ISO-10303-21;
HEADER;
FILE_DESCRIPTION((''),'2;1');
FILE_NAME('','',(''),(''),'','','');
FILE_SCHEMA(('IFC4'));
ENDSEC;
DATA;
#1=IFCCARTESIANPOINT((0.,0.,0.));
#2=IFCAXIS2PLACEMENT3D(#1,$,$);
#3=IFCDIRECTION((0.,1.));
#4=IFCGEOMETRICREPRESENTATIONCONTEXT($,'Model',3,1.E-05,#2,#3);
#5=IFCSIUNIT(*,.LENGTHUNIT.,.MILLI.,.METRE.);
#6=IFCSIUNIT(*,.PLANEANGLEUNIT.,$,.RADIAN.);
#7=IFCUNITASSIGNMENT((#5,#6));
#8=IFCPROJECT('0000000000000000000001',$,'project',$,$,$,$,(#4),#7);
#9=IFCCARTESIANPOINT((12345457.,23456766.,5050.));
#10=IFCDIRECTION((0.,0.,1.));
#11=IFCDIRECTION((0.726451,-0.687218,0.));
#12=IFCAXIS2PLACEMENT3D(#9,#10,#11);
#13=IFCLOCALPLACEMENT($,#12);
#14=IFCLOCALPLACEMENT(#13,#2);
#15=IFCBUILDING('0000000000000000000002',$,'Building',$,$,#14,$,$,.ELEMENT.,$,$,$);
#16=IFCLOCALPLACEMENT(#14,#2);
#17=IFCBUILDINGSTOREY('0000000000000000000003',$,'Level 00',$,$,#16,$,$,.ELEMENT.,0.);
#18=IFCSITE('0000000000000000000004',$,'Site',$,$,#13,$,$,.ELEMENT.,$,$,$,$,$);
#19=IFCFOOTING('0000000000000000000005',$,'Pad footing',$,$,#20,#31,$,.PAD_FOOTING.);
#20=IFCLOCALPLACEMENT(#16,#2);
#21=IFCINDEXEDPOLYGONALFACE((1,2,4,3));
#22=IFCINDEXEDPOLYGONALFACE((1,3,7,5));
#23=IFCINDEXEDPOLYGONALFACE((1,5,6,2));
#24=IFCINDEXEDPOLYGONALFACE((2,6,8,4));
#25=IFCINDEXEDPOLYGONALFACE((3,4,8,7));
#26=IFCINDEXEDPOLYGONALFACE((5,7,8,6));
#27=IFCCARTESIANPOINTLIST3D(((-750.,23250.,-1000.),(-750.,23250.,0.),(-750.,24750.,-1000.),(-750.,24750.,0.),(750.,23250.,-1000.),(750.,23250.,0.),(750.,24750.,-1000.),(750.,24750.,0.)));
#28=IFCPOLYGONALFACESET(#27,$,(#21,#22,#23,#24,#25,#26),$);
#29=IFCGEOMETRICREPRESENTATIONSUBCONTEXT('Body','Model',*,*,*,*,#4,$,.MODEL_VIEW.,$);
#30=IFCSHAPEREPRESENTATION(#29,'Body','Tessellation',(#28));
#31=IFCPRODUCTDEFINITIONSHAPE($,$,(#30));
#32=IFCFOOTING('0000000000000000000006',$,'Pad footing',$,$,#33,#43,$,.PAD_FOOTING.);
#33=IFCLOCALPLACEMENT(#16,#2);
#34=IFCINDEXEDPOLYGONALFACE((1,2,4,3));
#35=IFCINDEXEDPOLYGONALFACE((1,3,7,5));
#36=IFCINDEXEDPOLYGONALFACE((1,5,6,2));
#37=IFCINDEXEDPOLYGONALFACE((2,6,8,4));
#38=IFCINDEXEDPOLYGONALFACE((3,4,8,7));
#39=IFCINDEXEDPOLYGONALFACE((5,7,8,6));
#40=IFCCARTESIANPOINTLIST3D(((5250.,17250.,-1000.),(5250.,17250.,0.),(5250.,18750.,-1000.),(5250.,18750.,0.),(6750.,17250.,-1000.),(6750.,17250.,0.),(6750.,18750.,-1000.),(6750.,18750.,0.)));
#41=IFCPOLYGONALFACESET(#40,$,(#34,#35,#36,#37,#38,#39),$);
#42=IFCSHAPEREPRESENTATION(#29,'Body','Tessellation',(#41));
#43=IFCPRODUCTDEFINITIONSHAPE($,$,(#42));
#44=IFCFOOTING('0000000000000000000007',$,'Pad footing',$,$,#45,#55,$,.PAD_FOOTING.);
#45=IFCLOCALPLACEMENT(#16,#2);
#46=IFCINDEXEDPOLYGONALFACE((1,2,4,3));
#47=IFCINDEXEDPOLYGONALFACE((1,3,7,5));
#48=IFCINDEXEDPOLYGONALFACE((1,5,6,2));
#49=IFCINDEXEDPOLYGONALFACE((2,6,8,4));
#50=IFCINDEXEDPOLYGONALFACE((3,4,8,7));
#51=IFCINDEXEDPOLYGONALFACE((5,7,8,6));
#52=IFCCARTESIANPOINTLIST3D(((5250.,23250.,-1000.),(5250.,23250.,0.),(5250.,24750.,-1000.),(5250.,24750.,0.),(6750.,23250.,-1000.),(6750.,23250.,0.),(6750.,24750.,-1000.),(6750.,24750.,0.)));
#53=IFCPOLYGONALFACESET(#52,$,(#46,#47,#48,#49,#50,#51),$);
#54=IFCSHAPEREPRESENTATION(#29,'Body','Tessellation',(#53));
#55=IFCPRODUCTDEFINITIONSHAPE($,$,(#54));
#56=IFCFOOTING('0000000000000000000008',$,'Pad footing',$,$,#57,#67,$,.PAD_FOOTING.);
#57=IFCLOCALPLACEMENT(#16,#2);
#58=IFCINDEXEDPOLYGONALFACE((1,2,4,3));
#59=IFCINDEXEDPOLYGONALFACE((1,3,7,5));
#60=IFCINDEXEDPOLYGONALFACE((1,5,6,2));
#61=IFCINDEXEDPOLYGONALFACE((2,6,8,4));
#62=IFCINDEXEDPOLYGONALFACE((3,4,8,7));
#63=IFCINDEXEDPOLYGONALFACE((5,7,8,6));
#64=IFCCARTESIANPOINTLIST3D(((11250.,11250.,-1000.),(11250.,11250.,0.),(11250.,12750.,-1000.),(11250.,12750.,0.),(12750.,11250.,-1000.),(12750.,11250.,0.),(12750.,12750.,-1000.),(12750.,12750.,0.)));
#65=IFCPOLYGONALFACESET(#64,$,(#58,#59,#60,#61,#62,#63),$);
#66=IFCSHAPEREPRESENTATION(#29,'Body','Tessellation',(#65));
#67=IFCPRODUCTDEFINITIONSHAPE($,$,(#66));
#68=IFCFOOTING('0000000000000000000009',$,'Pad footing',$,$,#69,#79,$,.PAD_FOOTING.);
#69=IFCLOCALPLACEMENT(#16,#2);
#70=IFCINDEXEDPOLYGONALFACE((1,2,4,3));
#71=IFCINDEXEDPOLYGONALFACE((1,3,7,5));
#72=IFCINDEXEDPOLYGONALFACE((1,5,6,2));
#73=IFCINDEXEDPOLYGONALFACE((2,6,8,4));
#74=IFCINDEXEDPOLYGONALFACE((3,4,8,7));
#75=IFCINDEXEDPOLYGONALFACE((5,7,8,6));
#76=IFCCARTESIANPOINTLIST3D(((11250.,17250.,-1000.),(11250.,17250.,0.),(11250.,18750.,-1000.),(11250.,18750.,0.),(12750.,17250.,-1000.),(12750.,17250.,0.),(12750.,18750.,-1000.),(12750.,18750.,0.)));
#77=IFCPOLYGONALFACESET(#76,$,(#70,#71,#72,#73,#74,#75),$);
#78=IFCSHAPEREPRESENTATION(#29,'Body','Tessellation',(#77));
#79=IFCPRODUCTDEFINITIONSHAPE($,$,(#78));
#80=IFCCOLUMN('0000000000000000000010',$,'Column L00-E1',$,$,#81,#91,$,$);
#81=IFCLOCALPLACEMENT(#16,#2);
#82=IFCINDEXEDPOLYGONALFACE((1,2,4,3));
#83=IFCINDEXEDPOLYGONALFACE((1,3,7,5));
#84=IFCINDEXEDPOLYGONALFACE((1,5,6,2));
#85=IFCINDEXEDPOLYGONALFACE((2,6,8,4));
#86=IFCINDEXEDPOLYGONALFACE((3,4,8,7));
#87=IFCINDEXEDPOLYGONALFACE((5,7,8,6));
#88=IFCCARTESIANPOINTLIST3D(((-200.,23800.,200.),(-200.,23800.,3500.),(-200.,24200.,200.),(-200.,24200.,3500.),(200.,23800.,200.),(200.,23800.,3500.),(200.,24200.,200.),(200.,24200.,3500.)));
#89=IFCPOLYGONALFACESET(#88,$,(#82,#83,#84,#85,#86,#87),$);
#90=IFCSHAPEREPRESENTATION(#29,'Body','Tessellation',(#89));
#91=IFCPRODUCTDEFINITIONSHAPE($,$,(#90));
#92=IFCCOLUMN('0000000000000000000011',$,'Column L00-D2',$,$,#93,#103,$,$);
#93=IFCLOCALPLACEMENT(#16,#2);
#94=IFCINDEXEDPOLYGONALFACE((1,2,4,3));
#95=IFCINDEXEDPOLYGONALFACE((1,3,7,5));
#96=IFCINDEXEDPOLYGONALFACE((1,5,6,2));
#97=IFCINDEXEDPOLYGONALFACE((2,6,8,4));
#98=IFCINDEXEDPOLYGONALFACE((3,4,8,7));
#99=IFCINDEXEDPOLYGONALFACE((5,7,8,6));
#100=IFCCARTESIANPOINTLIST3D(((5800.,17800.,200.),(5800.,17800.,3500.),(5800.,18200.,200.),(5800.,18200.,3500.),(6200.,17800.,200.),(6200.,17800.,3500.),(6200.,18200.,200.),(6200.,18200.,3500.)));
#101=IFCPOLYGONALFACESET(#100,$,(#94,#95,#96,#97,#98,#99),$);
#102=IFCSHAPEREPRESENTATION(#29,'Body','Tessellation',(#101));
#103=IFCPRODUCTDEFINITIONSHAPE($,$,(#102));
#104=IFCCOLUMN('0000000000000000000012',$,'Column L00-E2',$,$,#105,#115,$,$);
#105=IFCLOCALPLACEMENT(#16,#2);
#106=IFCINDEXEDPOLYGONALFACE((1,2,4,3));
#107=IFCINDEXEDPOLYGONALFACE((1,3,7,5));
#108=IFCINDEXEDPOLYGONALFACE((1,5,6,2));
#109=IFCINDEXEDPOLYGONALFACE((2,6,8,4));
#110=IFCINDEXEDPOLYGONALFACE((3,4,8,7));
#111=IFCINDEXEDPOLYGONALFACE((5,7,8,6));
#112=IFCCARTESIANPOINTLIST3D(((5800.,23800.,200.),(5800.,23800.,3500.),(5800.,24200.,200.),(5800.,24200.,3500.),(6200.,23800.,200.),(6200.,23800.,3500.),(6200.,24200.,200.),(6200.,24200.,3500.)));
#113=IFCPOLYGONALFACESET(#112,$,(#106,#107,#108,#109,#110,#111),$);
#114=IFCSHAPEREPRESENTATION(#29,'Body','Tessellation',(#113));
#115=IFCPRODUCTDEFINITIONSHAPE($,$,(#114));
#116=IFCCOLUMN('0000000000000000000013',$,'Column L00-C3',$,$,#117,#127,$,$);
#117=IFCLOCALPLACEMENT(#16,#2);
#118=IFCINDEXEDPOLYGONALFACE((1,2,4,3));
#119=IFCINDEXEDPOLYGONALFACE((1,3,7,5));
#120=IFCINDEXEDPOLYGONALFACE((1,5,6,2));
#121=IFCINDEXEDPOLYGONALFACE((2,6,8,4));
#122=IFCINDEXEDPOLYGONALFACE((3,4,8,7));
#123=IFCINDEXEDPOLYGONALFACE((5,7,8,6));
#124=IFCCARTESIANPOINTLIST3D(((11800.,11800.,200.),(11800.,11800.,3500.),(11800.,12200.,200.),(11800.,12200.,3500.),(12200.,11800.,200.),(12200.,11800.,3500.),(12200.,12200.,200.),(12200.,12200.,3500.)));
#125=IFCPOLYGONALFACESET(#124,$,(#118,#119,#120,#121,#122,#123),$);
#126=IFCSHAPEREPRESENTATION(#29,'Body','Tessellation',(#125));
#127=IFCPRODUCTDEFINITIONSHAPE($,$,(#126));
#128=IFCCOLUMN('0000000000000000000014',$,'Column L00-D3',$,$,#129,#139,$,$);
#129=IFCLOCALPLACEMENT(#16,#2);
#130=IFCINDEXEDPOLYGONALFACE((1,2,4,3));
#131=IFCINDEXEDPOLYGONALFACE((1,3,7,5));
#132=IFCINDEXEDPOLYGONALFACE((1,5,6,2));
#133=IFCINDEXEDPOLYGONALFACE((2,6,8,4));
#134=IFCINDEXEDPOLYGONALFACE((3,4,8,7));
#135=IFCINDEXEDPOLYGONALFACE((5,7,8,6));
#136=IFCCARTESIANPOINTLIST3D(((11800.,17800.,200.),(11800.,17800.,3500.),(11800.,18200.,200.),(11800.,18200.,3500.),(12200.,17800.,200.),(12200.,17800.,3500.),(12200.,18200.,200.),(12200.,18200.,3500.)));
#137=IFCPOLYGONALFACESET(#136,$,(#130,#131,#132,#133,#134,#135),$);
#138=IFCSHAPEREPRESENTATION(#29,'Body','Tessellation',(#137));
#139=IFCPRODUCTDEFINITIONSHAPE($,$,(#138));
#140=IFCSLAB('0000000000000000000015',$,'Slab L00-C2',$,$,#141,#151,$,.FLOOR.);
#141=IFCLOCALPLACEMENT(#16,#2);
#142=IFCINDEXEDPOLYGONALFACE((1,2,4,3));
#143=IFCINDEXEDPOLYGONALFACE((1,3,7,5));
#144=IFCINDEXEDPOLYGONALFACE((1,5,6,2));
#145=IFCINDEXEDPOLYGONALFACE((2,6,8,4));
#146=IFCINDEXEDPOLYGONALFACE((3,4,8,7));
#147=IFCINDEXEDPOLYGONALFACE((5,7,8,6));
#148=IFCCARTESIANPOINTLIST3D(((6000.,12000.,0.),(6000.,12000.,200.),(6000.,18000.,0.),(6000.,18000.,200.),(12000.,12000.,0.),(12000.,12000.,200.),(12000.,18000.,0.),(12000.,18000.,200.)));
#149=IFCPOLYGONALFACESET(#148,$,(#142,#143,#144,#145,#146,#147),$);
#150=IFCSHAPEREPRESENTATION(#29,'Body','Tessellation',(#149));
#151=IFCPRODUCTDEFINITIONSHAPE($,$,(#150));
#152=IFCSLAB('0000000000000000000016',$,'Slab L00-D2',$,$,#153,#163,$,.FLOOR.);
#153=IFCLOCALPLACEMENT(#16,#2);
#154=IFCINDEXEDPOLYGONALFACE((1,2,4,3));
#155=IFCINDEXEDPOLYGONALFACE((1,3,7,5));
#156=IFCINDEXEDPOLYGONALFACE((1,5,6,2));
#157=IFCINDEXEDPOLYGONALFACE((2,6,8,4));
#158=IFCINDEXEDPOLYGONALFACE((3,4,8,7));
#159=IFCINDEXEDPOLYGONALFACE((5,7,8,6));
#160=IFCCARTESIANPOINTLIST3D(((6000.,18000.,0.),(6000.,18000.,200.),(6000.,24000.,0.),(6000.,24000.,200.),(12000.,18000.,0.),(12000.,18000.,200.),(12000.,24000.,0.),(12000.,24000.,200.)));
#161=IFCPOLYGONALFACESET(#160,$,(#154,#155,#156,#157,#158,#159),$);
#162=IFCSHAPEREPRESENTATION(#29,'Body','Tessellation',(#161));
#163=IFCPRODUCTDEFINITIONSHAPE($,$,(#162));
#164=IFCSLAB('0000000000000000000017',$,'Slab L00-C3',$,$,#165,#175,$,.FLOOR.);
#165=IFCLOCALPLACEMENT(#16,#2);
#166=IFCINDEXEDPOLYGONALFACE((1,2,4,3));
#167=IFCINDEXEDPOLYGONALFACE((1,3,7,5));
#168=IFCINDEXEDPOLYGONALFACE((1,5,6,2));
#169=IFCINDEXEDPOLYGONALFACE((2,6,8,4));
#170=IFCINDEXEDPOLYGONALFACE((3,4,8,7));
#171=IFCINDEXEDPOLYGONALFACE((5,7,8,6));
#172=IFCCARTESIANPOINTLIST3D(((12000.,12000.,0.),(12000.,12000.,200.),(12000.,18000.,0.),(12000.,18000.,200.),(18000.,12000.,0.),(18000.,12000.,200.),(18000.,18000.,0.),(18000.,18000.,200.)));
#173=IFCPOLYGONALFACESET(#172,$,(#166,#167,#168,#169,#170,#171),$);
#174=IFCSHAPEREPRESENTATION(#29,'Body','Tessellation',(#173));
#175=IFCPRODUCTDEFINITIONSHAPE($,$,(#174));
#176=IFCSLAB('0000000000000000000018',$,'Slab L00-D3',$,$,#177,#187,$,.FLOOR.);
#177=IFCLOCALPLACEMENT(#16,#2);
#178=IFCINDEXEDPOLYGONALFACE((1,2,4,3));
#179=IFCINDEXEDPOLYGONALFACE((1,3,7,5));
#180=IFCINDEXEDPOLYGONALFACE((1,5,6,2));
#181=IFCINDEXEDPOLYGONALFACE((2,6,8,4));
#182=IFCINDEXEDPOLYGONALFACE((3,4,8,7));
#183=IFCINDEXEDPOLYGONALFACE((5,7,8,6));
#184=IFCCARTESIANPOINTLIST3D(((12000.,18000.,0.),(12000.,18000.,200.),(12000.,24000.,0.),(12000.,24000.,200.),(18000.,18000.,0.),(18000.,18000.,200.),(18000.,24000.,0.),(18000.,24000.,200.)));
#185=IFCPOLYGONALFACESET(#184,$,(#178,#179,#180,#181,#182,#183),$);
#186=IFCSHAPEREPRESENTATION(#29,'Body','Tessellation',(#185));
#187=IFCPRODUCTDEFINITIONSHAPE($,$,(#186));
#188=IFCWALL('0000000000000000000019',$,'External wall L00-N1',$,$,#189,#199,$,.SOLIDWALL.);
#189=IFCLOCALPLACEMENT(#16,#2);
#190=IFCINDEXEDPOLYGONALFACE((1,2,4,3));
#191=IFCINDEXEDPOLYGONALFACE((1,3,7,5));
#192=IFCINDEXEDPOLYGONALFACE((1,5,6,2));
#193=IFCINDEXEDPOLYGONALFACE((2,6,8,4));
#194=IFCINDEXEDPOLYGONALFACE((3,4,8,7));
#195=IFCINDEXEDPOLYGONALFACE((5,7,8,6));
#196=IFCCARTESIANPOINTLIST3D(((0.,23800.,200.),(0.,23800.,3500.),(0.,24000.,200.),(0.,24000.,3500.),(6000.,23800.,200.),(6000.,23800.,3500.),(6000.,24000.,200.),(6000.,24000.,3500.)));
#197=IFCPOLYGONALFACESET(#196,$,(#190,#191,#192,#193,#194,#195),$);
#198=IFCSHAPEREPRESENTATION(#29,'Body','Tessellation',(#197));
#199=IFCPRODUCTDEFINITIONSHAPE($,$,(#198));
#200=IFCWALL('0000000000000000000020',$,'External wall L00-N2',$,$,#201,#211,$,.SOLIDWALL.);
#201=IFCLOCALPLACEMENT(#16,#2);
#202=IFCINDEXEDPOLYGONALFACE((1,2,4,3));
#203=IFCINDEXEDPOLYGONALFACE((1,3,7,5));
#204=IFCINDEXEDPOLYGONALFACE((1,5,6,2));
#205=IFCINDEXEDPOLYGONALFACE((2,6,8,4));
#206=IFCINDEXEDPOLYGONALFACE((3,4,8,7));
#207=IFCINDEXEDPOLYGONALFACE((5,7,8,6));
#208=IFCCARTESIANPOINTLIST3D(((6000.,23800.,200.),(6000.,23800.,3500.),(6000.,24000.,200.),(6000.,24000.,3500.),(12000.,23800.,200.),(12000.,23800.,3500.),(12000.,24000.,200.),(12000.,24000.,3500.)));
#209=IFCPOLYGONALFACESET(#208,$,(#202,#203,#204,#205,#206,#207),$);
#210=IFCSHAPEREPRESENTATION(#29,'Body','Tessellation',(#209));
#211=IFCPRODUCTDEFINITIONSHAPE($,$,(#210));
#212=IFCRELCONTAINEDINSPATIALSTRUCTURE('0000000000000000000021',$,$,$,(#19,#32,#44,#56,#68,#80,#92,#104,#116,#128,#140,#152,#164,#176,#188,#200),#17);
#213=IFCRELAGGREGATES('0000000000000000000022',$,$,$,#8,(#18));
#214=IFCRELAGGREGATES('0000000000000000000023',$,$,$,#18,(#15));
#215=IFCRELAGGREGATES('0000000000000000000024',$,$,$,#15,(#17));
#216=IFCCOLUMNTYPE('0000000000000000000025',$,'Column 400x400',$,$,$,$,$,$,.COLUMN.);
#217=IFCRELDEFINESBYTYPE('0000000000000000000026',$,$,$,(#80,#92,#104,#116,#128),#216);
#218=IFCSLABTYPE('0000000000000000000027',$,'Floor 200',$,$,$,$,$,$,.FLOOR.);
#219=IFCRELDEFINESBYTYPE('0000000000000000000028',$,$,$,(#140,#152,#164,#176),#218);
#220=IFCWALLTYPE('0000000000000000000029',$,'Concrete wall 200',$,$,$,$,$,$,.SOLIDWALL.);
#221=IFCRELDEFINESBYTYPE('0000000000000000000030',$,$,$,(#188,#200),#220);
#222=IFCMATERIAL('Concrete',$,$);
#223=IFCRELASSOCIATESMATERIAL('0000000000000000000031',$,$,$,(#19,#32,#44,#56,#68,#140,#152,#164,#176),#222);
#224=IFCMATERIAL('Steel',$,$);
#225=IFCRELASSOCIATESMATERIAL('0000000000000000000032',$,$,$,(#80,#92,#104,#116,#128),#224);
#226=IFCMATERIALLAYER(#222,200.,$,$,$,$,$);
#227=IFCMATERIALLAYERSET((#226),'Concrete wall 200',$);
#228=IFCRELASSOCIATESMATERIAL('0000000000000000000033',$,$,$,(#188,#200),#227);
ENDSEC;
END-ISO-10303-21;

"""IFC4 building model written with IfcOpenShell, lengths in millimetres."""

from ifc_helpers import new_model, si_unit, direction, frame, origin, place, context, subcontext, project, spatial, rectangle, extrude, material, layer, layer_set, layer_usage, type_object, element, save


model = new_model("IFC4")

# Units and contexts
model_context = context("Model", 3, precision=1e-05, world=origin(), true_north=direction((0.0, 1.0)))
body_context = subcontext(model_context, "Body", "Model", "MODEL_VIEW")
ifc_project = project(units=[si_unit("LENGTHUNIT", "METRE", prefix="MILLI"), si_unit("PLANEANGLEUNIT", "RADIAN")], contexts=[model_context])

# Site, building, storey
site_placement = place(None, frame((12345457.0, 23456766.0, 5050.0), z_axis=(0.0, 0.0, 1.0), x_axis=(0.726451, -0.687218, 0.0)))
site = spatial("IfcSite", under=ifc_project, at=site_placement, Name="Site", CompositionType="ELEMENT")
building_placement = place(site_placement, origin())
building = spatial("IfcBuilding", under=site, at=building_placement, Name="Building", CompositionType="ELEMENT")
storey_placement = place(building_placement, origin())
storey = spatial("IfcBuildingStorey", under=building, at=storey_placement, Name="Level 00", CompositionType="ELEMENT", Elevation=0.0)

# Footings
ifc_material_1 = material(Name="Concrete")
for number, where, name in (
    (1, (-750.0, 23250.0, -1000.0), "Pad footing"),
    (2, (5250.0, 17250.0, -1000.0), "Pad footing"),
    (3, (5250.0, 23250.0, -1000.0), "Pad footing"),
    (4, (11250.0, 11250.0, -1000.0), "Pad footing"),
    (5, (11250.0, 17250.0, -1000.0), "Pad footing"),
):
    element("IfcFooting", number, at=place(storey_placement, frame(where)), inside=storey, material=ifc_material_1, Name=name, PredefinedType="PAD_FOOTING", context=body_context, shape_type="SweptSolid", body=[
        extrude(rectangle(XDim=1500.0, YDim=1500.0), frame((750.0, 750.0, 0.0)), (0.0, 0.0, 1.0), 1000.0),
    ])

# Columns
ifc_material_2 = material(Name="Steel")
column_type = type_object("IfcColumnType", Name="Column 400x400", PredefinedType="COLUMN")
for number, where, name in (
    (6, (-200.0, 23800.0, 200.0), "Column L00-E1"),
    (7, (5800.0, 17800.0, 200.0), "Column L00-D2"),
    (8, (5800.0, 23800.0, 200.0), "Column L00-E2"),
    (9, (11800.0, 11800.0, 200.0), "Column L00-C3"),
    (10, (11800.0, 17800.0, 200.0), "Column L00-D3"),
):
    element("IfcColumn", number, at=place(storey_placement, frame(where)), inside=storey, type_object=column_type, material=ifc_material_2, Name=name, context=body_context, shape_type="SweptSolid", body=[
        extrude(rectangle(XDim=400.0, YDim=400.0), frame((200.0, 200.0, 0.0)), (0.0, 0.0, 1.0), 3300.0),
    ])

# Slabs
slab_type = type_object("IfcSlabType", Name="Floor 200", PredefinedType="FLOOR")
for number, where, name in (
    (11, (6000.0, 12000.0, 0.0), "Slab L00-C2"),
    (12, (6000.0, 18000.0, 0.0), "Slab L00-D2"),
    (13, (12000.0, 12000.0, 0.0), "Slab L00-C3"),
    (14, (12000.0, 18000.0, 0.0), "Slab L00-D3"),
):
    element("IfcSlab", number, at=place(storey_placement, frame(where)), inside=storey, type_object=slab_type, material=ifc_material_1, Name=name, PredefinedType="FLOOR", context=body_context, shape_type="SweptSolid", body=[
        extrude(rectangle(XDim=6000.0, YDim=6000.0), frame((3000.0, 3000.0, 0.0)), (0.0, 0.0, 1.0), 200.0),
    ])

# Walls
ifc_layer_1 = layer(ifc_material_1, 200.0)
ifc_layer_set_1 = layer_set([ifc_layer_1], Name="Concrete wall 200")
ifc_layer_usage_1 = layer_usage(ifc_layer_set_1, "AXIS2", "POSITIVE", 0.0)
wall_type_1 = type_object("IfcWallType", Name="Concrete wall 200", PredefinedType="SOLIDWALL")
for number, where, name in (
    (15, (0.0, 23800.0, 200.0), "External wall L00-N1"),
    (16, (6000.0, 23800.0, 200.0), "External wall L00-N2"),
):
    element("IfcWall", number, at=place(storey_placement, frame(where)), inside=storey, type_object=wall_type_1, material=ifc_layer_usage_1, Name=name, PredefinedType="SOLIDWALL", context=body_context, shape_type="SweptSolid", body=[
        extrude(rectangle(XDim=6000.0, YDim=200.0), frame((3000.0, 100.0, 0.0)), (0.0, 0.0, 1.0), 3300.0),
    ])

save(model, "model.ifc")
